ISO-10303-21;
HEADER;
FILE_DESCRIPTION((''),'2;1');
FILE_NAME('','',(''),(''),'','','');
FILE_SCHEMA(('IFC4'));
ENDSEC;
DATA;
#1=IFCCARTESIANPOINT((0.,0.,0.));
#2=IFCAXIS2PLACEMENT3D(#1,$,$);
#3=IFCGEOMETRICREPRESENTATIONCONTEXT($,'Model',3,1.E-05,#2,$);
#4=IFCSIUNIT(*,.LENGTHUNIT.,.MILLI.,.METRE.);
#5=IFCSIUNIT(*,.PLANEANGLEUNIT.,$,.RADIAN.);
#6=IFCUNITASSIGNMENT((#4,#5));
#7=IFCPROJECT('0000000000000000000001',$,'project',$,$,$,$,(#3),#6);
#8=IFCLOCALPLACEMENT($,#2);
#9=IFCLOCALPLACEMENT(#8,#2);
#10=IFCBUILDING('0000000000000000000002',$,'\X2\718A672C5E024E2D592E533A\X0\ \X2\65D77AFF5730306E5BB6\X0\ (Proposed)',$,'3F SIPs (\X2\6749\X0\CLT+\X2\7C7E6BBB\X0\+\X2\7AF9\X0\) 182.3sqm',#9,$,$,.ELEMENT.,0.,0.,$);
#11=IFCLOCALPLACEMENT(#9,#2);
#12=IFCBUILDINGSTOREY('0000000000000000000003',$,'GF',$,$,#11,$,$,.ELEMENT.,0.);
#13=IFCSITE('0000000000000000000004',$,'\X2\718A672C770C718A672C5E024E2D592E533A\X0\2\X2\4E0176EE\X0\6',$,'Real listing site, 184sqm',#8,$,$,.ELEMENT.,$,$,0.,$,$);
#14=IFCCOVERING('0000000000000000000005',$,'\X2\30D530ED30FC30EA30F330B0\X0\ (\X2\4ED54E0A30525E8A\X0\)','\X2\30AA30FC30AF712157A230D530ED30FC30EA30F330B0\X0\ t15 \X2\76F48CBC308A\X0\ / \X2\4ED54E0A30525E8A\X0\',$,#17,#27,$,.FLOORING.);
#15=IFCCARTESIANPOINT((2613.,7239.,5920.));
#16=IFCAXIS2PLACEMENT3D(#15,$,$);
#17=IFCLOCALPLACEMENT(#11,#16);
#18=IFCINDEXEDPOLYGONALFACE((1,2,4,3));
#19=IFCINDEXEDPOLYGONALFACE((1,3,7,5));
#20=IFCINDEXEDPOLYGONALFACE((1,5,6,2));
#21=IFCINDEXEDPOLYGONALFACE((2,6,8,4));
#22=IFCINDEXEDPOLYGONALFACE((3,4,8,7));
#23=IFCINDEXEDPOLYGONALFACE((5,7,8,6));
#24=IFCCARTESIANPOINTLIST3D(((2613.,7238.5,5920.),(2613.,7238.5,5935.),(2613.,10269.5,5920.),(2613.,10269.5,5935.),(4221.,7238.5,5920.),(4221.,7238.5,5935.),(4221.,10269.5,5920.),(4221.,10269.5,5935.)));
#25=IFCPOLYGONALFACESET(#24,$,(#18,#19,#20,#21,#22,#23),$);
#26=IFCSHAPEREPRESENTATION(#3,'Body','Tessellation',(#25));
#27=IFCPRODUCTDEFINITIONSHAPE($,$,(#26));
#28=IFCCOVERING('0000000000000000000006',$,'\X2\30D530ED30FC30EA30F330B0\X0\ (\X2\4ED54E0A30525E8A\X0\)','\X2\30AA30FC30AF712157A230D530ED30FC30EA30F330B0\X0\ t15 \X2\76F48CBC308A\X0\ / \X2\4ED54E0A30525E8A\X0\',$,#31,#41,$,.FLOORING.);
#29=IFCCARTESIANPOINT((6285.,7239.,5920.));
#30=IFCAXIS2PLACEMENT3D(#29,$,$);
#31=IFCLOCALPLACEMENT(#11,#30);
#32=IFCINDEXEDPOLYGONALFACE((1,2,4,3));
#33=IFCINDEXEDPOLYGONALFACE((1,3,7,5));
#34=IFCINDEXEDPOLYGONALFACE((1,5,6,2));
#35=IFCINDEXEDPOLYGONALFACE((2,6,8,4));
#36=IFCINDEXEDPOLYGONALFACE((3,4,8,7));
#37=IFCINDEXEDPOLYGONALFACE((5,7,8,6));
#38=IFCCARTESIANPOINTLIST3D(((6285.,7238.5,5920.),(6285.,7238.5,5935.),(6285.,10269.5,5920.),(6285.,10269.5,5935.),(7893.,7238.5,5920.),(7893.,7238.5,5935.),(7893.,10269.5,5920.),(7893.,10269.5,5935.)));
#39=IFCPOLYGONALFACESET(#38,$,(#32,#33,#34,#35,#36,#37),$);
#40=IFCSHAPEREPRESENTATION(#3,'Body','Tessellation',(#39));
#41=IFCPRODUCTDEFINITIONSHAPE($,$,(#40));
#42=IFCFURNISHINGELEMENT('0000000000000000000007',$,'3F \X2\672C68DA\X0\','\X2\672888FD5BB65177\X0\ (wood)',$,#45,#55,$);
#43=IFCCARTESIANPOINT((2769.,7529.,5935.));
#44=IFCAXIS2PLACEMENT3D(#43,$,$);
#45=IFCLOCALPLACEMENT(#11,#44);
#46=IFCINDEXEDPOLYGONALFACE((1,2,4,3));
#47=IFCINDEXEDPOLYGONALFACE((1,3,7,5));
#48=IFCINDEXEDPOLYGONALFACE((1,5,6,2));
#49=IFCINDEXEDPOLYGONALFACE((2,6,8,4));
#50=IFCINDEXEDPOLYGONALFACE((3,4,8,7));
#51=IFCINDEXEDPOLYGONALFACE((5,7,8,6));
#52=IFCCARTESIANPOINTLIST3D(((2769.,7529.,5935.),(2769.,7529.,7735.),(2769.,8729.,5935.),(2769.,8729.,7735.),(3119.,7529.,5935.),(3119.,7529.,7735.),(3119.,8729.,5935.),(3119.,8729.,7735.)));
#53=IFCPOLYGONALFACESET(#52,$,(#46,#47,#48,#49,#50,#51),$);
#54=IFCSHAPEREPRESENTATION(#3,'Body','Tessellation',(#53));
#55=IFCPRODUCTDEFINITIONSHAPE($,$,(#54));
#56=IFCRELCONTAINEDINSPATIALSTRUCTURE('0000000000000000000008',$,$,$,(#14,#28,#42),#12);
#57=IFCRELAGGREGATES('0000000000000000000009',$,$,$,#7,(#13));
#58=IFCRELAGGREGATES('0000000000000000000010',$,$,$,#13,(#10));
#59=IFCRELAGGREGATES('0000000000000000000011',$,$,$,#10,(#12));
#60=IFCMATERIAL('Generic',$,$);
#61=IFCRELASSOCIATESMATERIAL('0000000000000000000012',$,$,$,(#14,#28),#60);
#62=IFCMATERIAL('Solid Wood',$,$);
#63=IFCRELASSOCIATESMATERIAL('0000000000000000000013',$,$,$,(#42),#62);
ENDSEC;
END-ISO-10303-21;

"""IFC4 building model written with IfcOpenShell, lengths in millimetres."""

from ifc_helpers import new_model, si_unit, frame, frame_2d, origin, place, context, project, spatial, rectangle, extrude, material, element, save


model = new_model("IFC4")

# Units and contexts
model_context = context("Model", 3, precision=1e-05, world=origin())
ifc_project = project(units=[si_unit("LENGTHUNIT", "METRE", prefix="MILLI"), si_unit("PLANEANGLEUNIT", "RADIAN")], contexts=[model_context])

# Site, building, storey
site_placement = place(None, origin())
site = spatial("IfcSite", under=ifc_project, at=site_placement, Name="熊本県熊本市中央区2丁目6", ObjectType="Real listing site, 184sqm", CompositionType="ELEMENT", RefElevation=0.0)
building_placement = place(site_placement, origin())
building = spatial("IfcBuilding", under=site, at=building_placement, Name="熊本市中央区 旗竿地の家 (Proposed)", ObjectType="3F SIPs (杉CLT+籾殻+竹) 182.3sqm", CompositionType="ELEMENT", ElevationOfRefHeight=0.0, ElevationOfTerrain=0.0)
storey_placement = place(building_placement, origin())
storey = spatial("IfcBuildingStorey", under=building, at=storey_placement, Name="GF", CompositionType="ELEMENT", Elevation=0.0)

# Shared definitions
ifc_material_1 = material(Name="Solid Wood")

# Shared definitions
ifc_material_2 = material(Name="Generic")

# Coverings
covering_1_placement = place(storey_placement, frame((2613.0, 7239.0, 5920.0)))
element("IfcCovering", 1, at=covering_1_placement, inside=storey, material=ifc_material_2, Name="フローリング (仕上げ床)", Description="オーク無垢フローリング t15 直貼り / 仕上げ床", PredefinedType="FLOORING", context=model_context, shape_type="SweptSolid", body=[
    extrude(rectangle(XDim=1608.0, YDim=3031.0, at=frame_2d((804.0, 1515.0))), frame((2613.0, 7239.0, 5920.0)), (0.0, 0.0, 1.0), 15.0),
])
covering_2_placement = place(storey_placement, frame((6285.0, 7239.0, 5920.0)))
element("IfcCovering", 2, at=covering_2_placement, inside=storey, material=ifc_material_2, Name="フローリング (仕上げ床)", Description="オーク無垢フローリング t15 直貼り / 仕上げ床", PredefinedType="FLOORING", context=model_context, shape_type="SweptSolid", body=[
    extrude(rectangle(XDim=1608.0, YDim=3031.0, at=frame_2d((804.0, 1515.0))), frame((6285.0, 7239.0, 5920.0)), (0.0, 0.0, 1.0), 15.0),
])

# Furnishing element
furnishing_placement = place(storey_placement, frame((2769.0, 7529.0, 5935.0)))
element("IfcFurnishingElement", 3, at=furnishing_placement, inside=storey, material=ifc_material_1, Name="3F 本棚", Description="木製家具 (wood)", context=model_context, shape_type="SweptSolid", body=[
    extrude(rectangle(XDim=350.0, YDim=1200.0, at=frame_2d((175.0, 600.0))), frame((2769.0, 7529.0, 5935.0)), (0.0, 0.0, 1.0), 1800.0),
])

save(model, "model.ifc")
